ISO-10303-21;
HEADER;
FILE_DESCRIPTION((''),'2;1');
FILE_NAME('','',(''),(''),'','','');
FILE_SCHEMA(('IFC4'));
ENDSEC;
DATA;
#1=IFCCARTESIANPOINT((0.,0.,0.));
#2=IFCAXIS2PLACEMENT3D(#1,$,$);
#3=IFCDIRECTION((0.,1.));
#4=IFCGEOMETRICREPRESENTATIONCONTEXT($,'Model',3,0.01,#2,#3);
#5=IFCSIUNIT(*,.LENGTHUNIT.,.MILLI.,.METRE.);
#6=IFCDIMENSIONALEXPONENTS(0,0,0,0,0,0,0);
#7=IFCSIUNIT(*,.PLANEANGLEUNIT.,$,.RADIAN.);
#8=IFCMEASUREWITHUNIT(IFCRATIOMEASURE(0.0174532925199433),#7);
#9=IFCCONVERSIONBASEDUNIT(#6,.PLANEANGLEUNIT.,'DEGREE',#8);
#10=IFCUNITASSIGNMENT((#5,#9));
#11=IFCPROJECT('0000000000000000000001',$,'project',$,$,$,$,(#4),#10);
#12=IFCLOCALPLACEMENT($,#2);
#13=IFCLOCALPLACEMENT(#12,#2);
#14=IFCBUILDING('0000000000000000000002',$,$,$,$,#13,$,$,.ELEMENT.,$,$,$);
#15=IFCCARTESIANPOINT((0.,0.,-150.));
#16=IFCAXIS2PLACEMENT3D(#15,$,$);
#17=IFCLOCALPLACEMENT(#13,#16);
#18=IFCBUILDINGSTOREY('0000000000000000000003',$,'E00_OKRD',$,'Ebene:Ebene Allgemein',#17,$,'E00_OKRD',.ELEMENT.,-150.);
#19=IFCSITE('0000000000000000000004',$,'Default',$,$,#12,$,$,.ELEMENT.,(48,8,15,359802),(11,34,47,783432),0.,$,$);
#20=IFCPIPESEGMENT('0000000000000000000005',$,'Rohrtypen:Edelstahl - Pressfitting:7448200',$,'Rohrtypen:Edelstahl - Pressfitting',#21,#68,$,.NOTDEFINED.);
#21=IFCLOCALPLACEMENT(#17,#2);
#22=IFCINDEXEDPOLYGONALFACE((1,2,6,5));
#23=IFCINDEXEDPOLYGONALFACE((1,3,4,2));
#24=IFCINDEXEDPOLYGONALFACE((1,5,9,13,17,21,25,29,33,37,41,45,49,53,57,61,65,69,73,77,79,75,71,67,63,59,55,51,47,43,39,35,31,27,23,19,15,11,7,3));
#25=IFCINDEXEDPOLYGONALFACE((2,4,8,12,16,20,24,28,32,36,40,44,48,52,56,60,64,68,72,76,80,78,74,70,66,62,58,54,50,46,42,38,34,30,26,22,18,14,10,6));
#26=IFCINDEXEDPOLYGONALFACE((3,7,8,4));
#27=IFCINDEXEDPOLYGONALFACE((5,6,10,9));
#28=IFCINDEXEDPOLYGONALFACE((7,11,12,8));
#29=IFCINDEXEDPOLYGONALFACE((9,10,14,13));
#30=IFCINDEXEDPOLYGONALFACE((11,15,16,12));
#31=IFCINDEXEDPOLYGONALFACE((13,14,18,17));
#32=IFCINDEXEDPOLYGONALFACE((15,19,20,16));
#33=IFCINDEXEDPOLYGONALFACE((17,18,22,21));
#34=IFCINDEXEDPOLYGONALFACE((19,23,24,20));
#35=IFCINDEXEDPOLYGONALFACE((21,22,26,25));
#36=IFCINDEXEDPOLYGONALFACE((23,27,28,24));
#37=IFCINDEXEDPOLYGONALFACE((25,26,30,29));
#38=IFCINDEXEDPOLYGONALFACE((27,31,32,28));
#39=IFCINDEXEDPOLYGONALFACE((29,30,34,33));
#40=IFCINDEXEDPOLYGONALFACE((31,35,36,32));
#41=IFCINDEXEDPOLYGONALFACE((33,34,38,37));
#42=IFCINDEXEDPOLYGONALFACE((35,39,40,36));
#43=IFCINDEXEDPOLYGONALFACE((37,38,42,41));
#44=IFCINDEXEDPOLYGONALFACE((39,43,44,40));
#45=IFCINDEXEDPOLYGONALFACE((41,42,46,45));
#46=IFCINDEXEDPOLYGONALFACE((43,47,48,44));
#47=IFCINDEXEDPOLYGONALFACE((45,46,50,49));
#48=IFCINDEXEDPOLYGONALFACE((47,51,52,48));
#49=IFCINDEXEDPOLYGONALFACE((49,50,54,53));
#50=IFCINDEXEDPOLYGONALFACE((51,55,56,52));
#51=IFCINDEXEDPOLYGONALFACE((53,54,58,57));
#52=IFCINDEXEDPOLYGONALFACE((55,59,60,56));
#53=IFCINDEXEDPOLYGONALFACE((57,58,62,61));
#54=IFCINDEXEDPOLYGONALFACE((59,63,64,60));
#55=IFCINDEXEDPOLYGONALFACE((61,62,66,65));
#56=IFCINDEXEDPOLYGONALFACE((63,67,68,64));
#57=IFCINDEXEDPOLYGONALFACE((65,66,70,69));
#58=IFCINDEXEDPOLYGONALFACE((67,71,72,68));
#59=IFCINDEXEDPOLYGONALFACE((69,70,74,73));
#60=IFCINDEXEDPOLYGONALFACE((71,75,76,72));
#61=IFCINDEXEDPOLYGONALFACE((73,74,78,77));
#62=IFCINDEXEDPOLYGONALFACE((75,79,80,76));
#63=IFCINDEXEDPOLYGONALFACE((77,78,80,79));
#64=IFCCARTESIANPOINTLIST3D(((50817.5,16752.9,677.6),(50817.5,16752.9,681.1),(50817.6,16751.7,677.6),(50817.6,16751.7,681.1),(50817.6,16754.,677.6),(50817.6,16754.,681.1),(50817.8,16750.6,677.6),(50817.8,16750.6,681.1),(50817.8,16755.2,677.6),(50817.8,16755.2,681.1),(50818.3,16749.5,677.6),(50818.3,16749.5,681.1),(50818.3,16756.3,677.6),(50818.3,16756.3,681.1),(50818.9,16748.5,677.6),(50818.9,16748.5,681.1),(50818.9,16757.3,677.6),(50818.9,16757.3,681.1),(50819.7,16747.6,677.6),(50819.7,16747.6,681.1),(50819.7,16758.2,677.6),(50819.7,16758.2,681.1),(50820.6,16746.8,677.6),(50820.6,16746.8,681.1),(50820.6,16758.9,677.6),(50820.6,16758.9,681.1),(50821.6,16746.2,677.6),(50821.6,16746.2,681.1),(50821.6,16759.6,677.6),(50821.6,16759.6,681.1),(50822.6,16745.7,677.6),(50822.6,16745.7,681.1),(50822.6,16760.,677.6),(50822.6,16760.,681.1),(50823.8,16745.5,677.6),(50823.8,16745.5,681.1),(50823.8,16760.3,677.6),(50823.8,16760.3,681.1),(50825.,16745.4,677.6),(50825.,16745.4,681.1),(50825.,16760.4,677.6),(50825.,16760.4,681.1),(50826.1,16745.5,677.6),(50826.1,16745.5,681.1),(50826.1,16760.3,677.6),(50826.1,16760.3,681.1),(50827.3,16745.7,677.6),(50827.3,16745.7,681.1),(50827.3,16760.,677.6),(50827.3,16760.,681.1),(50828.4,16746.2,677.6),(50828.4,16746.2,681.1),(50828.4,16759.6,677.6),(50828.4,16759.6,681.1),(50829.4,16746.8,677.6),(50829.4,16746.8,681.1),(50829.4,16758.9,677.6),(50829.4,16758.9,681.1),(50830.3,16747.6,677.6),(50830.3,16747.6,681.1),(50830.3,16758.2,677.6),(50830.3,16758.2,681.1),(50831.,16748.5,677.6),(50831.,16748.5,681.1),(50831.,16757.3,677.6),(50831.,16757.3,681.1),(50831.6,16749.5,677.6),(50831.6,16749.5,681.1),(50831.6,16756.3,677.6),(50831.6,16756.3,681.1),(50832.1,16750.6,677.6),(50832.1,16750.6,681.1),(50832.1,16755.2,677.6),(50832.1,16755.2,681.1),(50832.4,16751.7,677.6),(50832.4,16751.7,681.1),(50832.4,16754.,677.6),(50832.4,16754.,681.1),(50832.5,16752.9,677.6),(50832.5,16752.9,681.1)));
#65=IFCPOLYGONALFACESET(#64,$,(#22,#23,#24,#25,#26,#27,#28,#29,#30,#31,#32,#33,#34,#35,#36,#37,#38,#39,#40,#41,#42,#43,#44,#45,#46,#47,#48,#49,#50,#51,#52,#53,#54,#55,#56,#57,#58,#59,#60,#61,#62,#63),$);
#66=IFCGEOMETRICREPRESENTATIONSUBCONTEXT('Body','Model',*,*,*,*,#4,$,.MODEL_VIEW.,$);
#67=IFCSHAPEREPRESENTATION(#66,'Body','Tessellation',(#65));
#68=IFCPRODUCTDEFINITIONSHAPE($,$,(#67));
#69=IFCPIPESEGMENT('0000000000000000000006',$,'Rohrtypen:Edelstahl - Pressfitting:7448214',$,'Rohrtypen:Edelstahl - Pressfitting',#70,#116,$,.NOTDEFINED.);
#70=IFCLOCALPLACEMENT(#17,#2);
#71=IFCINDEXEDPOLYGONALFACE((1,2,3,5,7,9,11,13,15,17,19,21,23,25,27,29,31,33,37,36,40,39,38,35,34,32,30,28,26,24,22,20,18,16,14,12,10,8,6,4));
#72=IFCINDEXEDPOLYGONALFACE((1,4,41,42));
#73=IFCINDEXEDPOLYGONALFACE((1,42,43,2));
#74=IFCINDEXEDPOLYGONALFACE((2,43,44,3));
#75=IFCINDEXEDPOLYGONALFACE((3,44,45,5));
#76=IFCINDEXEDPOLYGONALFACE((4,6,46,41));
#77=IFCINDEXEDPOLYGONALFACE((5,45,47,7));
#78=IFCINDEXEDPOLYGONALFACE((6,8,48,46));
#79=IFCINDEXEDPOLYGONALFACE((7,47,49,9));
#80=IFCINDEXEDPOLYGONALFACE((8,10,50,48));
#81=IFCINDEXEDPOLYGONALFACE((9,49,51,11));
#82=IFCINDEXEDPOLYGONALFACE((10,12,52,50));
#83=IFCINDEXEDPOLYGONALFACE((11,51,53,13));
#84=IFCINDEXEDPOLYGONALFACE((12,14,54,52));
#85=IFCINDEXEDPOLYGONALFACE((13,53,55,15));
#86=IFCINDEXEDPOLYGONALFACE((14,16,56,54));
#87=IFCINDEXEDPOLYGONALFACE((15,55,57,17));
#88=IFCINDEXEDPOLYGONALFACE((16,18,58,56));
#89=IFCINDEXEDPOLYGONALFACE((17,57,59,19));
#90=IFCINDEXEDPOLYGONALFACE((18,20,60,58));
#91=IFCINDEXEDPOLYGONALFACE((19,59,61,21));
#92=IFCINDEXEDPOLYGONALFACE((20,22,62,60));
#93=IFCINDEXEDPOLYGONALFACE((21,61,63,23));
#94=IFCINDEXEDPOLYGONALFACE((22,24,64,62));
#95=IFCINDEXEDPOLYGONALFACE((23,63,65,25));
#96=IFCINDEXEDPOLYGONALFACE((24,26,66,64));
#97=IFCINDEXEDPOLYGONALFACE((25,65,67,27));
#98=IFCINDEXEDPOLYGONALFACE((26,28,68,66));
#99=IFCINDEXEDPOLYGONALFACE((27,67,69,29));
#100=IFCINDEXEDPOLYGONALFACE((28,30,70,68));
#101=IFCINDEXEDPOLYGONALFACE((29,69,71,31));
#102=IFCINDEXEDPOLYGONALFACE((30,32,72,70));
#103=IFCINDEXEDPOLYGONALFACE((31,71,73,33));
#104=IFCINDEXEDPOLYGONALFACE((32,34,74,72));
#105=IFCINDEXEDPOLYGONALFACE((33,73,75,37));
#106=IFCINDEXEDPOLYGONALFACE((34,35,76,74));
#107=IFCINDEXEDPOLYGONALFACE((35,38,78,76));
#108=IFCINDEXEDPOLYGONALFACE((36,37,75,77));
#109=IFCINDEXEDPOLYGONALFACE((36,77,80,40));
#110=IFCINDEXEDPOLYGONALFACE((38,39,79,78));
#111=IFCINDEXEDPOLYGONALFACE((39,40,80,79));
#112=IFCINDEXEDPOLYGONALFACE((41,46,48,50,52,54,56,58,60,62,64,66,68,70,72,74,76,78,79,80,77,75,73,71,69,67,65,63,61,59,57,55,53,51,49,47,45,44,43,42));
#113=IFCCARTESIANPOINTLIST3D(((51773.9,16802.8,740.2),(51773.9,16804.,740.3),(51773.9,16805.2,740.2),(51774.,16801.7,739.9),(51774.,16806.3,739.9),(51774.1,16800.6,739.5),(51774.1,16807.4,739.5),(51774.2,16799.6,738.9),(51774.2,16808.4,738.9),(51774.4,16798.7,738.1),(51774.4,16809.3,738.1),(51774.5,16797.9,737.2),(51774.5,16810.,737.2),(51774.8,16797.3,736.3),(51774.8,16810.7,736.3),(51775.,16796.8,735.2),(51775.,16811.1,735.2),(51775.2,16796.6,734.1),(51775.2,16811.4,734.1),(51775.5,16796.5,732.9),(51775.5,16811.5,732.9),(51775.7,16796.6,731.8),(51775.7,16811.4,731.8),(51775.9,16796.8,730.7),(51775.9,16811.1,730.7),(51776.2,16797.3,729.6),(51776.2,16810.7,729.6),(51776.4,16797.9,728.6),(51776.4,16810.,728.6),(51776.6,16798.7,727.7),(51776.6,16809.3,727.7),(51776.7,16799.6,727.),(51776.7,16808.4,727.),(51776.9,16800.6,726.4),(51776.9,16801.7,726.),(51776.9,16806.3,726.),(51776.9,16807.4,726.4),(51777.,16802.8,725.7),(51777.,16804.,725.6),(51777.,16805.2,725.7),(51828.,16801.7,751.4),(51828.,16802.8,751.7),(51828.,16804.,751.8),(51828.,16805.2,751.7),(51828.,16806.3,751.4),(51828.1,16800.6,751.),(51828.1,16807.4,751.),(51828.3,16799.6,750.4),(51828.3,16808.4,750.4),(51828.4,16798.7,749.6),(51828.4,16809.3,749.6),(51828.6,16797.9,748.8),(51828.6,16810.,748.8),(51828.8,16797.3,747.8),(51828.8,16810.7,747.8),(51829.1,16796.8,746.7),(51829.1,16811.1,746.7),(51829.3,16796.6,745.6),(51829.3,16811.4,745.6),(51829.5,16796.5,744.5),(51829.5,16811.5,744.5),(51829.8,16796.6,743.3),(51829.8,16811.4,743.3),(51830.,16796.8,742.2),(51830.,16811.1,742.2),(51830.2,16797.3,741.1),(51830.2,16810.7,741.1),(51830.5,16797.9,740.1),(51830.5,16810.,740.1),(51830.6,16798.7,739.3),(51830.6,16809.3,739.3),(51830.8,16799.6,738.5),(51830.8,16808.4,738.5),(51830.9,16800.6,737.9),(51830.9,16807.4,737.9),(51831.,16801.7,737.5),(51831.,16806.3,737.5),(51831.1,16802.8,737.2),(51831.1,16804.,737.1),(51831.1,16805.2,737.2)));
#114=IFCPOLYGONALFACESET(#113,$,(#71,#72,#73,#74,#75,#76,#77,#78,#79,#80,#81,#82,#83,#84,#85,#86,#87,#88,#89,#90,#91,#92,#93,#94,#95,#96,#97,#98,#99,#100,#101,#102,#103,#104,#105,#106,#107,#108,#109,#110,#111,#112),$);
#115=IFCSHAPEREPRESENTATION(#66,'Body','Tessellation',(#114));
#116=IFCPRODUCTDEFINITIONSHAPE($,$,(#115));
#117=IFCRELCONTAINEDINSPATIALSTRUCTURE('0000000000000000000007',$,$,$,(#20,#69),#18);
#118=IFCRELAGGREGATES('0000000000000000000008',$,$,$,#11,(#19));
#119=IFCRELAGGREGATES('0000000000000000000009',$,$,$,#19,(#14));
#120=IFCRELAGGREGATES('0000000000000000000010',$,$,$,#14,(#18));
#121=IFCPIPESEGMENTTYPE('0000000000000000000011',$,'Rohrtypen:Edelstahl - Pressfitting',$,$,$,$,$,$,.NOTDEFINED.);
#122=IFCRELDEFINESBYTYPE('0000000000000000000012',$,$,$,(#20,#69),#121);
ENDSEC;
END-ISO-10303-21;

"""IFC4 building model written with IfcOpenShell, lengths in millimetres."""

from ifc_helpers import new_model, entity, si_unit, converted_unit, direction, frame, origin, place, context, subcontext, project, spatial, indexed_curve, outline, extrude, type_object, element, save


model = new_model("IFC4")

# Units and contexts
model_context = context("Model", 3, precision=0.01, world=origin(), true_north=direction((0.0, 1.0)))
body_context = subcontext(model_context, "Body", "Model", "MODEL_VIEW")
ifc_project = project(units=[si_unit("LENGTHUNIT", "METRE", prefix="MILLI"), converted_unit("PLANEANGLEUNIT", "DEGREE", entity("IfcRatioMeasure", 0.0174532925199433), si_unit("PLANEANGLEUNIT", "RADIAN"), dimensions=[0, 0, 0, 0, 0, 0, 0])], contexts=[model_context])

# Site, building, storey
site_placement = place(None, origin())
site = spatial("IfcSite", under=ifc_project, at=site_placement, Name="Default", CompositionType="ELEMENT", RefLatitude=(48, 8, 15, 359802), RefLongitude=(11, 34, 47, 783432), RefElevation=0.0)
building_placement = place(site_placement, origin())
building = spatial("IfcBuilding", under=site, at=building_placement, CompositionType="ELEMENT")
storey_placement = place(building_placement, frame((0.0, 0.0, -150.0)))
storey = spatial("IfcBuildingStorey", under=building, at=storey_placement, Name="E00_OKRD", ObjectType="Ebene:Ebene Allgemein", LongName="E00_OKRD", CompositionType="ELEMENT", Elevation=-150.0)

# Pipe segments
pipe_segment_type_1 = type_object("IfcPipeSegmentType", Name="Rohrtypen:Edelstahl - Pressfitting", PredefinedType="NOTDEFINED")
pipe_segment_1_placement = place(storey_placement, origin())
element("IfcPipeSegment", 1, at=pipe_segment_1_placement, inside=storey, type_object=pipe_segment_type_1, Name="Rohrtypen:Edelstahl - Pressfitting:7448200", ObjectType="Rohrtypen:Edelstahl - Pressfitting", PredefinedType="NOTDEFINED", context=body_context, shape_type="SweptSolid", body=[
    extrude(outline(indexed_curve([(7.5, 0.0), (7.4, 1.2), (7.1, 2.3), (6.7, 3.4), (6.1, 4.4), (5.3, 5.3), (4.4, 6.1), (3.4, 6.7), (2.3, 7.1), (1.2, 7.4), (0.0, 7.5), (-1.2, 7.4), (-2.3, 7.1), (-3.4, 6.7), (-4.4, 6.1), (-5.3, 5.3), (-6.1, 4.4), (-6.7, 3.4), (-7.1, 2.3), (-7.4, 1.2), (-7.5, 0.0), (-7.4, -1.2), (-7.1, -2.3), (-6.7, -3.4), (-6.1, -4.4), (-5.3, -5.3), (-4.4, -6.1), (-3.4, -6.7), (-2.3, -7.1), (-1.2, -7.4), (0.0, -7.5), (1.2, -7.4), (2.3, -7.1), (3.4, -6.7), (4.4, -6.1), (5.3, -5.3), (6.1, -4.4), (6.7, -3.4), (7.1, -2.3), (7.4, -1.2), (7.5, 0.0)], self_intersect=False)), frame((50825.0, 16752.9, 677.6)), (0.0, 0.0, 1.0), 3.5),
])
pipe_segment_2_placement = place(storey_placement, origin())
element("IfcPipeSegment", 2, at=pipe_segment_2_placement, inside=storey, type_object=pipe_segment_type_1, Name="Rohrtypen:Edelstahl - Pressfitting:7448214", ObjectType="Rohrtypen:Edelstahl - Pressfitting", PredefinedType="NOTDEFINED", context=body_context, shape_type="SweptSolid", body=[
    extrude(outline(indexed_curve([(7.5, 0.0), (7.4, 1.2), (7.1, 2.3), (6.7, 3.4), (6.1, 4.4), (5.3, 5.3), (4.4, 6.1), (3.4, 6.7), (2.3, 7.1), (1.2, 7.4), (0.0, 7.5), (-1.2, 7.4), (-2.3, 7.1), (-3.4, 6.7), (-4.4, 6.1), (-5.3, 5.3), (-6.1, 4.4), (-6.7, 3.4), (-7.1, 2.3), (-7.4, 1.2), (-7.5, 0.0), (-7.4, -1.2), (-7.1, -2.3), (-6.7, -3.4), (-6.1, -4.4), (-5.3, -5.3), (-4.4, -6.1), (-3.4, -6.7), (-2.3, -7.1), (-1.2, -7.4), (0.0, -7.5), (1.2, -7.4), (2.3, -7.1), (3.4, -6.7), (4.4, -6.1), (5.3, -5.3), (6.1, -4.4), (6.7, -3.4), (7.1, -2.3), (7.4, -1.2), (7.5, 0.0)], self_intersect=False)), frame((51775.5, 16804.0, 732.9), z_axis=(0.978044, 0.0, 0.208399), x_axis=(0.0, -1.0, 0.0)), (0.0, 0.0, 1.0), 55.3),
])

save(model, "model.ifc")
